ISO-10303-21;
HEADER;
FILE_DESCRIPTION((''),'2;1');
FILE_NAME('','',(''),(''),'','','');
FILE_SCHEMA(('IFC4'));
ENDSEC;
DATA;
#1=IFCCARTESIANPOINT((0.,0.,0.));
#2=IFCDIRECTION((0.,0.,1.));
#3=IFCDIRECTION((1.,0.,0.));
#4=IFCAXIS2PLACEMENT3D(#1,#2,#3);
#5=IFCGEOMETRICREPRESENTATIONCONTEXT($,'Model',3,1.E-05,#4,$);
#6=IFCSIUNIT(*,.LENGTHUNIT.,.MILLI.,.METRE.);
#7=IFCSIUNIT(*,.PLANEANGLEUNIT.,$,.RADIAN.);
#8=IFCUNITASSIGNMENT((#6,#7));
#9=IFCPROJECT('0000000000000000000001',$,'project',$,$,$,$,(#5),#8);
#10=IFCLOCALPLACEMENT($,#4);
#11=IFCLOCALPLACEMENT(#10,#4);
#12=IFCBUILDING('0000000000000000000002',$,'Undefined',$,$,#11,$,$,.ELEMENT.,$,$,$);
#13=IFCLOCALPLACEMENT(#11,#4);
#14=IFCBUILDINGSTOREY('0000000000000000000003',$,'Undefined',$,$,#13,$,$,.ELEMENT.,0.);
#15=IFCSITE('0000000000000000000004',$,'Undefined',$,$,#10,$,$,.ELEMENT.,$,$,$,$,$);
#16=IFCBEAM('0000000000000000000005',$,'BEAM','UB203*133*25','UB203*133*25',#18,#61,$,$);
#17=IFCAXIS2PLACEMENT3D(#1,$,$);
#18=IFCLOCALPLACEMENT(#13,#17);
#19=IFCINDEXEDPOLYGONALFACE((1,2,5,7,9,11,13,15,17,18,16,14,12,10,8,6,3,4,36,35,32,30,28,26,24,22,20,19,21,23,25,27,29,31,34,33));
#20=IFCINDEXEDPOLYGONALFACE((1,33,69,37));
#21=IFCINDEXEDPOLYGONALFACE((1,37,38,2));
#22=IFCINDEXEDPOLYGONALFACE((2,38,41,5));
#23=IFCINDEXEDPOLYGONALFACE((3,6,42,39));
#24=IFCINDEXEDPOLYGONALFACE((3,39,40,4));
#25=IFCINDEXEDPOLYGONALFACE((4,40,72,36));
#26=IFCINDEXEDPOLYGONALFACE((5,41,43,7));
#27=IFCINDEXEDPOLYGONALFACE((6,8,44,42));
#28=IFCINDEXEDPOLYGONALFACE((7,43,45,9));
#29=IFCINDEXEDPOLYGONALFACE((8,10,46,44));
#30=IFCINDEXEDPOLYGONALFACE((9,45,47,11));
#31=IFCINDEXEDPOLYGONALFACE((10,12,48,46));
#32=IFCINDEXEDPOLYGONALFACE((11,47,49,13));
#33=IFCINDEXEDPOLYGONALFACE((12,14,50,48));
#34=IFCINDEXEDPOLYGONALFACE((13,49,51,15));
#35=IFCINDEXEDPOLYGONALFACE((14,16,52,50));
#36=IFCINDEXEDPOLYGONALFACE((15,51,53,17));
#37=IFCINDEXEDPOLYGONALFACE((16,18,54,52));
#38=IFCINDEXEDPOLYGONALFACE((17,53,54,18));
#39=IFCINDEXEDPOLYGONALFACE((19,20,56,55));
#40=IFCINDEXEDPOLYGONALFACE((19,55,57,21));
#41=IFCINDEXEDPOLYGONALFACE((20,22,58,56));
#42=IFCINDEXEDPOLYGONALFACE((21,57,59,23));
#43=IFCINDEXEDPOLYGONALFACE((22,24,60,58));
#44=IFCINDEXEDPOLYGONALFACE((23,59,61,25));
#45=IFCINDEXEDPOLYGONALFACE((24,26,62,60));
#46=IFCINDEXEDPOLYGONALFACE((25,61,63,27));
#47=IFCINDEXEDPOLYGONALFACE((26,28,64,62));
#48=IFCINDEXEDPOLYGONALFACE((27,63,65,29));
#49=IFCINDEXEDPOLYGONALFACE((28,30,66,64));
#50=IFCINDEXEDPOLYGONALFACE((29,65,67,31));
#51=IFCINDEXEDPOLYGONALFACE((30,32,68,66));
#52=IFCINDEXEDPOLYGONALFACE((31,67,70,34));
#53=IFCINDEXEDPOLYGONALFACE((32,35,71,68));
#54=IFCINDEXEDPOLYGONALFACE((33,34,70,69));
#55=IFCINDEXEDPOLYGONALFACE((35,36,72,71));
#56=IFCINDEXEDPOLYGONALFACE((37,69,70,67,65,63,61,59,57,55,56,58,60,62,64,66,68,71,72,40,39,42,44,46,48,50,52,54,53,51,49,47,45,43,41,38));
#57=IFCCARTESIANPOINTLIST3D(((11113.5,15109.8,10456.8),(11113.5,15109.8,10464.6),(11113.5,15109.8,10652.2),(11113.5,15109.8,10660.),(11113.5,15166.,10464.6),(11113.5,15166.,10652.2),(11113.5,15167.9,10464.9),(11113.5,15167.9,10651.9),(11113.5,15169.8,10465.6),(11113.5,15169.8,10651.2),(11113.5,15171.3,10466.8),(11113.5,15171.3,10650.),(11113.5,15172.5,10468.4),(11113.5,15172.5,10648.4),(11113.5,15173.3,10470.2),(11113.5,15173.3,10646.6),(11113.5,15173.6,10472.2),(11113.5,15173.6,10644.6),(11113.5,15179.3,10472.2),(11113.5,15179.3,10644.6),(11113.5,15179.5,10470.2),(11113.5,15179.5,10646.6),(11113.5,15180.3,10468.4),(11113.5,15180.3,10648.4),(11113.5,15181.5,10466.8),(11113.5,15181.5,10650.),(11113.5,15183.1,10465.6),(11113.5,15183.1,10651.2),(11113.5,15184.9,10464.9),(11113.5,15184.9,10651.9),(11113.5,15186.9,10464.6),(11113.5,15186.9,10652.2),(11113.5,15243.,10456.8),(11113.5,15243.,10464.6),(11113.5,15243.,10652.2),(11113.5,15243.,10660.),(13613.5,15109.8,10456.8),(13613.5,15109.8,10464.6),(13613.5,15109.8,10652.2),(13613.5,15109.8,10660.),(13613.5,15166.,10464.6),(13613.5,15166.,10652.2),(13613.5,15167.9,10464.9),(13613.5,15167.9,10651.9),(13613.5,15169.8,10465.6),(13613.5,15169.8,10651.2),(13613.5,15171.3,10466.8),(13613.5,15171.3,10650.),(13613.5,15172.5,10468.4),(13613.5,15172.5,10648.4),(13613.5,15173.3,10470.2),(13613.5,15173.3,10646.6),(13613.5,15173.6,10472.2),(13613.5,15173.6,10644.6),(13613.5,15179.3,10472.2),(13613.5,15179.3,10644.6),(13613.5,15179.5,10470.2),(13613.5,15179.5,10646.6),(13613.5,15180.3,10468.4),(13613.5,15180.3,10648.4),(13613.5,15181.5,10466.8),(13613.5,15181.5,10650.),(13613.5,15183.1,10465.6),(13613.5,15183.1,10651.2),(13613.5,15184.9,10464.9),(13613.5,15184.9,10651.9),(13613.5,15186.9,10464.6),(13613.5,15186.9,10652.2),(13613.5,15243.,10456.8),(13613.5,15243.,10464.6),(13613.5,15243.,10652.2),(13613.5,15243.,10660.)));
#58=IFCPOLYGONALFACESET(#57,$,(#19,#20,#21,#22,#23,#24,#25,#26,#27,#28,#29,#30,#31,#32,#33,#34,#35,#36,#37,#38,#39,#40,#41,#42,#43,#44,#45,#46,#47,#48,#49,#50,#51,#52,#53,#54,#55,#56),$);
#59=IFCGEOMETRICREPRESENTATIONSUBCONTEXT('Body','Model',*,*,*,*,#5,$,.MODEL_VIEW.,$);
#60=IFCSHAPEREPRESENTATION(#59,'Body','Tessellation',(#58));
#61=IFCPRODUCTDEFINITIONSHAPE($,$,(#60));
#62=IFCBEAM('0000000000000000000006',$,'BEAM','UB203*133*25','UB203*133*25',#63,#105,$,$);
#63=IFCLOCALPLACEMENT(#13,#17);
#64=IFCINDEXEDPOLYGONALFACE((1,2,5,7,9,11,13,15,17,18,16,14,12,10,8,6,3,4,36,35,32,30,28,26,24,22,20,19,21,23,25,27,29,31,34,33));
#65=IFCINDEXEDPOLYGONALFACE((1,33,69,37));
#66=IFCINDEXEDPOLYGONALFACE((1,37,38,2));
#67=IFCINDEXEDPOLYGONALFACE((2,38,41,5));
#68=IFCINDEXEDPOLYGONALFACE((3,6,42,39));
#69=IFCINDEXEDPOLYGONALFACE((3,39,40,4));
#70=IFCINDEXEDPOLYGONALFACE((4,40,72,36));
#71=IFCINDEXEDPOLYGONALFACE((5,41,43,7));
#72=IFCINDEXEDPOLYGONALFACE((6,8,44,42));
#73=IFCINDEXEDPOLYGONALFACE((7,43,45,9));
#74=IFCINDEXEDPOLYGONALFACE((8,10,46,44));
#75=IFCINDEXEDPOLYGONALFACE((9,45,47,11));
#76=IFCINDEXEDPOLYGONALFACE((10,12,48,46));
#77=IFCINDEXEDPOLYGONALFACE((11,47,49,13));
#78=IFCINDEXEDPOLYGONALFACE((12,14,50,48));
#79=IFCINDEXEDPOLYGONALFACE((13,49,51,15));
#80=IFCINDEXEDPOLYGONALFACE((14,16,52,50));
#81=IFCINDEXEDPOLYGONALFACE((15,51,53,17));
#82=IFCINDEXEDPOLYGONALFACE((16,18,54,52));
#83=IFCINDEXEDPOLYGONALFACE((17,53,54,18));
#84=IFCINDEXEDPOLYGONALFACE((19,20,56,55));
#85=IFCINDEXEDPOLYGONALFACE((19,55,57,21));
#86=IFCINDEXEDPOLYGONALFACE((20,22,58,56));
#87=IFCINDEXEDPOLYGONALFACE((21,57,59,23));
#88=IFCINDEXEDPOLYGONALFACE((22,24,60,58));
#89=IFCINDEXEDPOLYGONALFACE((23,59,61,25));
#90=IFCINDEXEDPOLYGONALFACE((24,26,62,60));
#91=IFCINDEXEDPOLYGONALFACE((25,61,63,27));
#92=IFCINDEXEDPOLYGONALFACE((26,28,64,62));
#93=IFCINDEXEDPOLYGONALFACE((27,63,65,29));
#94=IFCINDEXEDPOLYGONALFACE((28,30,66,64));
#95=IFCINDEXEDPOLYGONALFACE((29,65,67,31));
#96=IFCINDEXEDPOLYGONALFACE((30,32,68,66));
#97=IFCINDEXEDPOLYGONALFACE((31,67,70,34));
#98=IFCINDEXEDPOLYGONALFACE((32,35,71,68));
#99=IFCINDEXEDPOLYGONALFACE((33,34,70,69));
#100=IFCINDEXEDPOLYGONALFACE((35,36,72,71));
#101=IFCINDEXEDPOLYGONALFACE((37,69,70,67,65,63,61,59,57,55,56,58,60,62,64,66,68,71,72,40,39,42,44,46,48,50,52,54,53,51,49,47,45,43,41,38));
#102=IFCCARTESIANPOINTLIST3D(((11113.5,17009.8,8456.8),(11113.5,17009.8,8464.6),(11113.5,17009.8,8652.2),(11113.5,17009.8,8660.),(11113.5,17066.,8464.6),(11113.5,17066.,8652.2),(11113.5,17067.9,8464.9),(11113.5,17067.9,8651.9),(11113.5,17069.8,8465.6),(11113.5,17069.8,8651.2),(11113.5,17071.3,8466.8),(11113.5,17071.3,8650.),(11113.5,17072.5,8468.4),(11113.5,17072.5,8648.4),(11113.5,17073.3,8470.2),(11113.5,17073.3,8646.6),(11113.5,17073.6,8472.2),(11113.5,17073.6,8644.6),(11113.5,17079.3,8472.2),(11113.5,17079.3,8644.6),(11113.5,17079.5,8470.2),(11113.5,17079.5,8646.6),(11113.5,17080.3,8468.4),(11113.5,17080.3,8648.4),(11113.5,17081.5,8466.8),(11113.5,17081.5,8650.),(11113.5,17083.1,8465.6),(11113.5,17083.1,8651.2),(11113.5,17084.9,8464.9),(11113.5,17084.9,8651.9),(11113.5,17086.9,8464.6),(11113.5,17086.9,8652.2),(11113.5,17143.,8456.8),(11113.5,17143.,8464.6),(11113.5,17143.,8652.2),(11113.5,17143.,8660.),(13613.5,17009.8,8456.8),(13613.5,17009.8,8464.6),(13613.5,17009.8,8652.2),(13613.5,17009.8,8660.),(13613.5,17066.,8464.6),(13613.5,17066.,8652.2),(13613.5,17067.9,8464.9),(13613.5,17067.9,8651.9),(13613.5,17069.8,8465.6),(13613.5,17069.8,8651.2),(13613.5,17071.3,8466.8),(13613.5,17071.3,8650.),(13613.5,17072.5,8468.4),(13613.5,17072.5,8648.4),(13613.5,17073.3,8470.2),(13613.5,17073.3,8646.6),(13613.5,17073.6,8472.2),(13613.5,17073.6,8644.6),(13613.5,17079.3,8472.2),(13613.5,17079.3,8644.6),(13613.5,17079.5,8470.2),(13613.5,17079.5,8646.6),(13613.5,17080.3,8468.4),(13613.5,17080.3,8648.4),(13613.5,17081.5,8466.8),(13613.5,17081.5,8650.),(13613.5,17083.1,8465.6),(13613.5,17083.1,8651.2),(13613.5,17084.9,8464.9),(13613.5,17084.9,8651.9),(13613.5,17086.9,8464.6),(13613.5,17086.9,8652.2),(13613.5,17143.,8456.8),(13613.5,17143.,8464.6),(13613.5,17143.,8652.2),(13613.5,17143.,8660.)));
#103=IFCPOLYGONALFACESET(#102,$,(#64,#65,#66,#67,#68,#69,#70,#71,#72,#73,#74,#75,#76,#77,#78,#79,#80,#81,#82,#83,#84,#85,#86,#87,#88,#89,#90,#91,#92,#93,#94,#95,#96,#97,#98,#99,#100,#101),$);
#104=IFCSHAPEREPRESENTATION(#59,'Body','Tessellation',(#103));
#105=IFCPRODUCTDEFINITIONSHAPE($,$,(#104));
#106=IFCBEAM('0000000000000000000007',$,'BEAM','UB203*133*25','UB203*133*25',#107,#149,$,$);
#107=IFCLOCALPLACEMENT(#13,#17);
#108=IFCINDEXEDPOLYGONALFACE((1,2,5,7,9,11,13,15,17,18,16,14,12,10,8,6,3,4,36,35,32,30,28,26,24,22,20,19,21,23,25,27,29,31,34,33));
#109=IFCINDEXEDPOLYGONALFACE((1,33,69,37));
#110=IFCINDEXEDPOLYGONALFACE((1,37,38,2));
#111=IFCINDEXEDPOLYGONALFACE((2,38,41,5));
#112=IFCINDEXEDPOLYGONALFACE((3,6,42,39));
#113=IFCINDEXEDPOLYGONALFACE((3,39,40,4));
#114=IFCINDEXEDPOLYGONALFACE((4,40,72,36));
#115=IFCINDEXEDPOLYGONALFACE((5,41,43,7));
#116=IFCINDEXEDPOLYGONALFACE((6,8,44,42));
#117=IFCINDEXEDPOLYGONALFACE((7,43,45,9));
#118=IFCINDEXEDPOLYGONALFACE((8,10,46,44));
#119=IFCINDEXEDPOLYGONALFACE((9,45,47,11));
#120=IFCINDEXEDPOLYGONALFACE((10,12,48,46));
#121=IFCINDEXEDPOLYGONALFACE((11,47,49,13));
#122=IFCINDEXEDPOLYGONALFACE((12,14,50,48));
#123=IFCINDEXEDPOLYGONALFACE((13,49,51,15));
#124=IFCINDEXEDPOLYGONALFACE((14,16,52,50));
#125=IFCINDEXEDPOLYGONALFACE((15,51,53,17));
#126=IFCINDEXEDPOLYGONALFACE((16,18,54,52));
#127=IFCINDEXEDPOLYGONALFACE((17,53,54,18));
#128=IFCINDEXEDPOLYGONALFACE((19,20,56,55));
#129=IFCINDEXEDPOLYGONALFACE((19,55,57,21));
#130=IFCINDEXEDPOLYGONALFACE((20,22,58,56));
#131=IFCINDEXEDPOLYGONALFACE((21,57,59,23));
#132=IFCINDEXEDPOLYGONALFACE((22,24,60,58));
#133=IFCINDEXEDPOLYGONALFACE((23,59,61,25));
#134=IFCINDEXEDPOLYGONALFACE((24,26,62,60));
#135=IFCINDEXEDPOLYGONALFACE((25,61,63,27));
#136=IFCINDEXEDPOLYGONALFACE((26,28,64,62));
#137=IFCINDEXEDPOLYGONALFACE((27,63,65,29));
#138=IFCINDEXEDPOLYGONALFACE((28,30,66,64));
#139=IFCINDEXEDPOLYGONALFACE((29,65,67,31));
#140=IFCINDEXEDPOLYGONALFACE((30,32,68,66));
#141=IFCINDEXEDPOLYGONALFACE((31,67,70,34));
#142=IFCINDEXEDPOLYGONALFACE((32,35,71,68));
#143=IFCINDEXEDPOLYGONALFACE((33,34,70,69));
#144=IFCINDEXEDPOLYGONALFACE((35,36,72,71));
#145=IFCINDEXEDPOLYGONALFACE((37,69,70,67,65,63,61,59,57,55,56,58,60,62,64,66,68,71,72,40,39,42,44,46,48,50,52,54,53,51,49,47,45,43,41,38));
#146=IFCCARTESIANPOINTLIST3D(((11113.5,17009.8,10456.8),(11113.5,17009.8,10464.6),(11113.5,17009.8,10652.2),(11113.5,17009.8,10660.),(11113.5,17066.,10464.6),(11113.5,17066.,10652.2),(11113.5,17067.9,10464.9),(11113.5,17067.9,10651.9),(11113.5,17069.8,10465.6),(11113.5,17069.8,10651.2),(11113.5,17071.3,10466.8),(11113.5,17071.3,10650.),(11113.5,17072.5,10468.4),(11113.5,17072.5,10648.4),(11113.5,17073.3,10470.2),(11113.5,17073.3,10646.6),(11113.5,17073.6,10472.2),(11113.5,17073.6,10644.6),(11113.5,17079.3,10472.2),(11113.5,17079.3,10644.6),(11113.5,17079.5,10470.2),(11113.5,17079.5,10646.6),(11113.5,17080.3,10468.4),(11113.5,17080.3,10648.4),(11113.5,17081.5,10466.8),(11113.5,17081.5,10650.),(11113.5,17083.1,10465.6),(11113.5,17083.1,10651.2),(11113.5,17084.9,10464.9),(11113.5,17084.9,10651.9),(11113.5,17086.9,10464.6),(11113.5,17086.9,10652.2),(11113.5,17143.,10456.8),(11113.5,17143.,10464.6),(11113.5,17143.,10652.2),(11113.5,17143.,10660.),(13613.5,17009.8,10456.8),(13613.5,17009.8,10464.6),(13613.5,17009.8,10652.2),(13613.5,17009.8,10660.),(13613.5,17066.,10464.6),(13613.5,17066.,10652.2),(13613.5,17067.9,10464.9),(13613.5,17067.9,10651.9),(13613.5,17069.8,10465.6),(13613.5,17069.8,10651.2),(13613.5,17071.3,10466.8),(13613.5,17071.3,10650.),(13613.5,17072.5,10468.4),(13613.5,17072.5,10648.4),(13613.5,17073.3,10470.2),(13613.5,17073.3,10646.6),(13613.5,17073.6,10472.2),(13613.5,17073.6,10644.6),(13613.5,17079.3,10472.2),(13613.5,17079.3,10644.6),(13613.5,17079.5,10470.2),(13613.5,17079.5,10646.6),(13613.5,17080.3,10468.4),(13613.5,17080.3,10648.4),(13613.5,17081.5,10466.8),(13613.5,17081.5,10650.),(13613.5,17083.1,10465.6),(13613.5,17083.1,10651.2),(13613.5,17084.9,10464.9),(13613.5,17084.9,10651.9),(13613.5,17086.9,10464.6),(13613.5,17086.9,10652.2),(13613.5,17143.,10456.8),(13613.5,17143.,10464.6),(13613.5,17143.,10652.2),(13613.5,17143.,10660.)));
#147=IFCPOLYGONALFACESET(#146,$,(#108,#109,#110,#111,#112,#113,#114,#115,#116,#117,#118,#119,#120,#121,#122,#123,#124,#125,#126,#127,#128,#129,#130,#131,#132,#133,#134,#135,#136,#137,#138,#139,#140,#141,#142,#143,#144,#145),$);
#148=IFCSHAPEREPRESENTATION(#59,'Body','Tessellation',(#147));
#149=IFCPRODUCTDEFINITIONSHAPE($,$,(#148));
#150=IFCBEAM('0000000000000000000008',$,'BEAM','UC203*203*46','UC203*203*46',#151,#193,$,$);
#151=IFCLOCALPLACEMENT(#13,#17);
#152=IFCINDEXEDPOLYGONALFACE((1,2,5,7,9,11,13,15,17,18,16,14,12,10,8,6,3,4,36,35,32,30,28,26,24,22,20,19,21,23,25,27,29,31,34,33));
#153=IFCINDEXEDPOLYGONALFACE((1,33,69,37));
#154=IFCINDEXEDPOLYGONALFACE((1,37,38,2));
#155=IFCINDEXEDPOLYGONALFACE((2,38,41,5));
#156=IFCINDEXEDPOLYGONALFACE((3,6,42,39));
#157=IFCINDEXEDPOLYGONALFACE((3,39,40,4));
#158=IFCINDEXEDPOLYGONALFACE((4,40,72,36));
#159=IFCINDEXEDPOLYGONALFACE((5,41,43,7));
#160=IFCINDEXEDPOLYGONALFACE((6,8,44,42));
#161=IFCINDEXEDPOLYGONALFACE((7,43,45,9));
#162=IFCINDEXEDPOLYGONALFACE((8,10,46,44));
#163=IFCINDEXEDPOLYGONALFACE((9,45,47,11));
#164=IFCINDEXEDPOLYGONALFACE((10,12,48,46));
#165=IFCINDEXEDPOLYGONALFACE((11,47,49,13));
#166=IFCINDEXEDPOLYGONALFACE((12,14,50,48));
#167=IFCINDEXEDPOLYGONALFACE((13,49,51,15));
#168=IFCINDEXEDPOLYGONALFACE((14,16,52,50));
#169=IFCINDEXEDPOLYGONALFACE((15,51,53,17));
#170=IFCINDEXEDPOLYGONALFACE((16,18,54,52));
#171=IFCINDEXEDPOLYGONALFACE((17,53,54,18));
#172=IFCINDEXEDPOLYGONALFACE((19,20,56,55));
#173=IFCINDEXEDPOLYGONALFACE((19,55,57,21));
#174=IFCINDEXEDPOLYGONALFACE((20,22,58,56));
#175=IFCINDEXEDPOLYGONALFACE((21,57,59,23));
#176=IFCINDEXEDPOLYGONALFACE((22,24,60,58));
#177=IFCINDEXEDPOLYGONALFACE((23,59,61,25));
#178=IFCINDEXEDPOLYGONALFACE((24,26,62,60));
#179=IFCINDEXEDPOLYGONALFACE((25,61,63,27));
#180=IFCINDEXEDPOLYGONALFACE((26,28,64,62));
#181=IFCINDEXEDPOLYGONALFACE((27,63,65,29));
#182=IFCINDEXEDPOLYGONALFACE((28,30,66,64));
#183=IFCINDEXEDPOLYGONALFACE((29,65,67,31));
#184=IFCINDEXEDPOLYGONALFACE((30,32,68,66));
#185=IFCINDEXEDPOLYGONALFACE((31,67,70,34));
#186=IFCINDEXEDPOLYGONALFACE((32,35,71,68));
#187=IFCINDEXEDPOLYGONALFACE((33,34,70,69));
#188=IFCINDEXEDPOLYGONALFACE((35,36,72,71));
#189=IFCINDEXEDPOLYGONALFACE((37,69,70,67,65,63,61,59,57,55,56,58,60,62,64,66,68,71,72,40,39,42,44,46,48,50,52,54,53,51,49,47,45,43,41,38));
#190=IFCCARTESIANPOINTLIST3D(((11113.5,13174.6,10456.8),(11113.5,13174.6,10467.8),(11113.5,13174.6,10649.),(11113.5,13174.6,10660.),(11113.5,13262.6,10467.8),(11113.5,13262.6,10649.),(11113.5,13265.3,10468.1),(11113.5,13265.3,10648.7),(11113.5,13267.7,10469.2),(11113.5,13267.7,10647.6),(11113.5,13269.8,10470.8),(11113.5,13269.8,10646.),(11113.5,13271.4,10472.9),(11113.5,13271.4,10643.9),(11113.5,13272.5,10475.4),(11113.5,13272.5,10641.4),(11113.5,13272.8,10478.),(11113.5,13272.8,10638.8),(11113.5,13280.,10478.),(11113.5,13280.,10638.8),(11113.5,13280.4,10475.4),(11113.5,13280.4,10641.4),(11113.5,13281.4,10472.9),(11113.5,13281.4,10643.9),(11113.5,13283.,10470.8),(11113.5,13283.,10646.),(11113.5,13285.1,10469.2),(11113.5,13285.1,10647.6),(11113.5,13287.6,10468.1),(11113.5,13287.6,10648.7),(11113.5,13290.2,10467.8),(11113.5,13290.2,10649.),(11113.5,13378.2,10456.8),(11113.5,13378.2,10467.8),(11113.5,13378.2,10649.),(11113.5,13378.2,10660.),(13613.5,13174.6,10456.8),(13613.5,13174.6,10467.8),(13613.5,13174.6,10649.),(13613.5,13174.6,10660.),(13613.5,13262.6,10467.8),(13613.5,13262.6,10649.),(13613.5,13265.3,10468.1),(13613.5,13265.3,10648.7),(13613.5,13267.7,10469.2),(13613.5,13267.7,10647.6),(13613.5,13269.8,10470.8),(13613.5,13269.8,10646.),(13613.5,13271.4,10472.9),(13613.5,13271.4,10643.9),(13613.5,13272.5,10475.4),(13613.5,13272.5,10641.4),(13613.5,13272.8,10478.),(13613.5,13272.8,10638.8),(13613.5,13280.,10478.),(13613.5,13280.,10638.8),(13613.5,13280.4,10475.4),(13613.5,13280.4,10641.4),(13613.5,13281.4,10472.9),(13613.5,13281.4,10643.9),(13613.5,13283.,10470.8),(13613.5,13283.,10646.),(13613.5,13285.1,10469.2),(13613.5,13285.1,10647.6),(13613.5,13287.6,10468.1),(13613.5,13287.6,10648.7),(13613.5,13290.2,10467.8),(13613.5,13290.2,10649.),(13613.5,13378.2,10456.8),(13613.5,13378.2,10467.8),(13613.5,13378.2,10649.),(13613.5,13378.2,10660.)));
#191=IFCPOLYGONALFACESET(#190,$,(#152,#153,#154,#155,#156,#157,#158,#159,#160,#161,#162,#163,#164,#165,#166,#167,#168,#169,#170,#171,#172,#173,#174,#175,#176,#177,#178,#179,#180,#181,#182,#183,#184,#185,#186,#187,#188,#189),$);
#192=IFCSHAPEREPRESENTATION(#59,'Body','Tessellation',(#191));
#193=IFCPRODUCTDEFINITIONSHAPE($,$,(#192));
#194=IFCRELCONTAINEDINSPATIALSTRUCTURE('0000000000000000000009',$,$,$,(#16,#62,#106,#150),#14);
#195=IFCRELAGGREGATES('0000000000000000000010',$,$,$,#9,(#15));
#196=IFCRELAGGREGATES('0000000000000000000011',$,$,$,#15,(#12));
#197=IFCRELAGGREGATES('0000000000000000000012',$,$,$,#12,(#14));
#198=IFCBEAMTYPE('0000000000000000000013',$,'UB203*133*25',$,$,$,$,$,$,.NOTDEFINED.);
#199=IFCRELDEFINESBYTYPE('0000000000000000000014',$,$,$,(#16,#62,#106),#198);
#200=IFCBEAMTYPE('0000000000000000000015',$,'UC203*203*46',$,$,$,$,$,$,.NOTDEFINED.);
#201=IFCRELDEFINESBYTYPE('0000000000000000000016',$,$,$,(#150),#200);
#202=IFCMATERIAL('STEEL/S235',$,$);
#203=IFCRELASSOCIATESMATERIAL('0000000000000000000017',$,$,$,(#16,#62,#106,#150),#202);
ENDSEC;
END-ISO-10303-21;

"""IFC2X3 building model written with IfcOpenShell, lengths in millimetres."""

from ifc_helpers import new_model, si_unit, frame, origin_with_axes, origin_2d_with_axis, place, context, subcontext, project, spatial, i_section, extrude, material, type_object, element, save


model = new_model("IFC2X3")

# Units and contexts
model_context = context("Model", 3, precision=1e-05, world=origin_with_axes())
body_context = subcontext(model_context, "Body", "Model", "MODEL_VIEW")
ifc_project = project(units=[si_unit("LENGTHUNIT", "METRE", prefix="MILLI"), si_unit("PLANEANGLEUNIT", "RADIAN")], contexts=[model_context])

# Site, building, storey
site_placement = place(None, origin_with_axes())
site = spatial("IfcSite", under=ifc_project, at=site_placement, Name="Undefined", CompositionType="ELEMENT")
building_placement = place(site_placement, origin_with_axes())
building = spatial("IfcBuilding", under=site, at=building_placement, Name="Undefined", CompositionType="ELEMENT")
storey_placement = place(building_placement, origin_with_axes())
storey = spatial("IfcBuildingStorey", under=building, at=storey_placement, Name="Undefined", CompositionType="ELEMENT", Elevation=0.0)

# Shared definitions
ifc_material = material(Name="STEEL/S235")

# Beams
beam_type_1 = type_object("IfcBeamType", Name="UB203*133*25", PredefinedType="NOTDEFINED")
for number, where, z_axis, x_axis, name in (
    (1, (11113.5, 15176.4, 10558.4), (0.0, 0.0, 1.0), (1.0, 0.0, 0.0), "BEAM"),
    (2, (11113.5, 17076.4, 8558.4), (0.0, 0.0, 1.0), (1.0, 0.0, 0.0), "BEAM"),
    (3, (11113.5, 17076.4, 10558.4), (0.0, 0.0, 1.0), (1.0, 0.0, 0.0), "BEAM"),
):
    element("IfcBeam", number, at=place(storey_placement, frame(where, z_axis=z_axis, x_axis=x_axis)), inside=storey, type_object=beam_type_1, material=ifc_material, Name=name, Description="UB203*133*25", ObjectType="UB203*133*25", context=body_context, shape_type="SweptSolid", body=[
        extrude(i_section(OverallWidth=133.2, OverallDepth=203.2, WebThickness=5.7, FlangeThickness=7.8, FilletRadius=7.6, at=origin_2d_with_axis()), frame((2500.0, 0.0, 0.0), z_axis=(-1.0, 0.0, 0.0), x_axis=(0.0, -1.0, 0.0)), (0.0, 0.0, 1.0), 2500.0),
    ])
beam_type_2 = type_object("IfcBeamType", Name="UC203*203*46", PredefinedType="NOTDEFINED")
for number, where, z_axis, x_axis, name in (
    (4, (11113.5, 13276.4, 10558.4), (0.0, 0.0, 1.0), (1.0, 0.0, 0.0), "BEAM"),
):
    element("IfcBeam", number, at=place(storey_placement, frame(where, z_axis=z_axis, x_axis=x_axis)), inside=storey, type_object=beam_type_2, material=ifc_material, Name=name, Description="UC203*203*46", ObjectType="UC203*203*46", context=body_context, shape_type="SweptSolid", body=[
        extrude(i_section(OverallWidth=203.6, OverallDepth=203.2, WebThickness=7.2, FlangeThickness=11.0, FilletRadius=10.2, at=origin_2d_with_axis()), frame((2500.0, 0.0, 0.0), z_axis=(-1.0, 0.0, 0.0), x_axis=(0.0, -1.0, 0.0)), (0.0, 0.0, 1.0), 2500.0),
    ])

save(model, "model.ifc")
